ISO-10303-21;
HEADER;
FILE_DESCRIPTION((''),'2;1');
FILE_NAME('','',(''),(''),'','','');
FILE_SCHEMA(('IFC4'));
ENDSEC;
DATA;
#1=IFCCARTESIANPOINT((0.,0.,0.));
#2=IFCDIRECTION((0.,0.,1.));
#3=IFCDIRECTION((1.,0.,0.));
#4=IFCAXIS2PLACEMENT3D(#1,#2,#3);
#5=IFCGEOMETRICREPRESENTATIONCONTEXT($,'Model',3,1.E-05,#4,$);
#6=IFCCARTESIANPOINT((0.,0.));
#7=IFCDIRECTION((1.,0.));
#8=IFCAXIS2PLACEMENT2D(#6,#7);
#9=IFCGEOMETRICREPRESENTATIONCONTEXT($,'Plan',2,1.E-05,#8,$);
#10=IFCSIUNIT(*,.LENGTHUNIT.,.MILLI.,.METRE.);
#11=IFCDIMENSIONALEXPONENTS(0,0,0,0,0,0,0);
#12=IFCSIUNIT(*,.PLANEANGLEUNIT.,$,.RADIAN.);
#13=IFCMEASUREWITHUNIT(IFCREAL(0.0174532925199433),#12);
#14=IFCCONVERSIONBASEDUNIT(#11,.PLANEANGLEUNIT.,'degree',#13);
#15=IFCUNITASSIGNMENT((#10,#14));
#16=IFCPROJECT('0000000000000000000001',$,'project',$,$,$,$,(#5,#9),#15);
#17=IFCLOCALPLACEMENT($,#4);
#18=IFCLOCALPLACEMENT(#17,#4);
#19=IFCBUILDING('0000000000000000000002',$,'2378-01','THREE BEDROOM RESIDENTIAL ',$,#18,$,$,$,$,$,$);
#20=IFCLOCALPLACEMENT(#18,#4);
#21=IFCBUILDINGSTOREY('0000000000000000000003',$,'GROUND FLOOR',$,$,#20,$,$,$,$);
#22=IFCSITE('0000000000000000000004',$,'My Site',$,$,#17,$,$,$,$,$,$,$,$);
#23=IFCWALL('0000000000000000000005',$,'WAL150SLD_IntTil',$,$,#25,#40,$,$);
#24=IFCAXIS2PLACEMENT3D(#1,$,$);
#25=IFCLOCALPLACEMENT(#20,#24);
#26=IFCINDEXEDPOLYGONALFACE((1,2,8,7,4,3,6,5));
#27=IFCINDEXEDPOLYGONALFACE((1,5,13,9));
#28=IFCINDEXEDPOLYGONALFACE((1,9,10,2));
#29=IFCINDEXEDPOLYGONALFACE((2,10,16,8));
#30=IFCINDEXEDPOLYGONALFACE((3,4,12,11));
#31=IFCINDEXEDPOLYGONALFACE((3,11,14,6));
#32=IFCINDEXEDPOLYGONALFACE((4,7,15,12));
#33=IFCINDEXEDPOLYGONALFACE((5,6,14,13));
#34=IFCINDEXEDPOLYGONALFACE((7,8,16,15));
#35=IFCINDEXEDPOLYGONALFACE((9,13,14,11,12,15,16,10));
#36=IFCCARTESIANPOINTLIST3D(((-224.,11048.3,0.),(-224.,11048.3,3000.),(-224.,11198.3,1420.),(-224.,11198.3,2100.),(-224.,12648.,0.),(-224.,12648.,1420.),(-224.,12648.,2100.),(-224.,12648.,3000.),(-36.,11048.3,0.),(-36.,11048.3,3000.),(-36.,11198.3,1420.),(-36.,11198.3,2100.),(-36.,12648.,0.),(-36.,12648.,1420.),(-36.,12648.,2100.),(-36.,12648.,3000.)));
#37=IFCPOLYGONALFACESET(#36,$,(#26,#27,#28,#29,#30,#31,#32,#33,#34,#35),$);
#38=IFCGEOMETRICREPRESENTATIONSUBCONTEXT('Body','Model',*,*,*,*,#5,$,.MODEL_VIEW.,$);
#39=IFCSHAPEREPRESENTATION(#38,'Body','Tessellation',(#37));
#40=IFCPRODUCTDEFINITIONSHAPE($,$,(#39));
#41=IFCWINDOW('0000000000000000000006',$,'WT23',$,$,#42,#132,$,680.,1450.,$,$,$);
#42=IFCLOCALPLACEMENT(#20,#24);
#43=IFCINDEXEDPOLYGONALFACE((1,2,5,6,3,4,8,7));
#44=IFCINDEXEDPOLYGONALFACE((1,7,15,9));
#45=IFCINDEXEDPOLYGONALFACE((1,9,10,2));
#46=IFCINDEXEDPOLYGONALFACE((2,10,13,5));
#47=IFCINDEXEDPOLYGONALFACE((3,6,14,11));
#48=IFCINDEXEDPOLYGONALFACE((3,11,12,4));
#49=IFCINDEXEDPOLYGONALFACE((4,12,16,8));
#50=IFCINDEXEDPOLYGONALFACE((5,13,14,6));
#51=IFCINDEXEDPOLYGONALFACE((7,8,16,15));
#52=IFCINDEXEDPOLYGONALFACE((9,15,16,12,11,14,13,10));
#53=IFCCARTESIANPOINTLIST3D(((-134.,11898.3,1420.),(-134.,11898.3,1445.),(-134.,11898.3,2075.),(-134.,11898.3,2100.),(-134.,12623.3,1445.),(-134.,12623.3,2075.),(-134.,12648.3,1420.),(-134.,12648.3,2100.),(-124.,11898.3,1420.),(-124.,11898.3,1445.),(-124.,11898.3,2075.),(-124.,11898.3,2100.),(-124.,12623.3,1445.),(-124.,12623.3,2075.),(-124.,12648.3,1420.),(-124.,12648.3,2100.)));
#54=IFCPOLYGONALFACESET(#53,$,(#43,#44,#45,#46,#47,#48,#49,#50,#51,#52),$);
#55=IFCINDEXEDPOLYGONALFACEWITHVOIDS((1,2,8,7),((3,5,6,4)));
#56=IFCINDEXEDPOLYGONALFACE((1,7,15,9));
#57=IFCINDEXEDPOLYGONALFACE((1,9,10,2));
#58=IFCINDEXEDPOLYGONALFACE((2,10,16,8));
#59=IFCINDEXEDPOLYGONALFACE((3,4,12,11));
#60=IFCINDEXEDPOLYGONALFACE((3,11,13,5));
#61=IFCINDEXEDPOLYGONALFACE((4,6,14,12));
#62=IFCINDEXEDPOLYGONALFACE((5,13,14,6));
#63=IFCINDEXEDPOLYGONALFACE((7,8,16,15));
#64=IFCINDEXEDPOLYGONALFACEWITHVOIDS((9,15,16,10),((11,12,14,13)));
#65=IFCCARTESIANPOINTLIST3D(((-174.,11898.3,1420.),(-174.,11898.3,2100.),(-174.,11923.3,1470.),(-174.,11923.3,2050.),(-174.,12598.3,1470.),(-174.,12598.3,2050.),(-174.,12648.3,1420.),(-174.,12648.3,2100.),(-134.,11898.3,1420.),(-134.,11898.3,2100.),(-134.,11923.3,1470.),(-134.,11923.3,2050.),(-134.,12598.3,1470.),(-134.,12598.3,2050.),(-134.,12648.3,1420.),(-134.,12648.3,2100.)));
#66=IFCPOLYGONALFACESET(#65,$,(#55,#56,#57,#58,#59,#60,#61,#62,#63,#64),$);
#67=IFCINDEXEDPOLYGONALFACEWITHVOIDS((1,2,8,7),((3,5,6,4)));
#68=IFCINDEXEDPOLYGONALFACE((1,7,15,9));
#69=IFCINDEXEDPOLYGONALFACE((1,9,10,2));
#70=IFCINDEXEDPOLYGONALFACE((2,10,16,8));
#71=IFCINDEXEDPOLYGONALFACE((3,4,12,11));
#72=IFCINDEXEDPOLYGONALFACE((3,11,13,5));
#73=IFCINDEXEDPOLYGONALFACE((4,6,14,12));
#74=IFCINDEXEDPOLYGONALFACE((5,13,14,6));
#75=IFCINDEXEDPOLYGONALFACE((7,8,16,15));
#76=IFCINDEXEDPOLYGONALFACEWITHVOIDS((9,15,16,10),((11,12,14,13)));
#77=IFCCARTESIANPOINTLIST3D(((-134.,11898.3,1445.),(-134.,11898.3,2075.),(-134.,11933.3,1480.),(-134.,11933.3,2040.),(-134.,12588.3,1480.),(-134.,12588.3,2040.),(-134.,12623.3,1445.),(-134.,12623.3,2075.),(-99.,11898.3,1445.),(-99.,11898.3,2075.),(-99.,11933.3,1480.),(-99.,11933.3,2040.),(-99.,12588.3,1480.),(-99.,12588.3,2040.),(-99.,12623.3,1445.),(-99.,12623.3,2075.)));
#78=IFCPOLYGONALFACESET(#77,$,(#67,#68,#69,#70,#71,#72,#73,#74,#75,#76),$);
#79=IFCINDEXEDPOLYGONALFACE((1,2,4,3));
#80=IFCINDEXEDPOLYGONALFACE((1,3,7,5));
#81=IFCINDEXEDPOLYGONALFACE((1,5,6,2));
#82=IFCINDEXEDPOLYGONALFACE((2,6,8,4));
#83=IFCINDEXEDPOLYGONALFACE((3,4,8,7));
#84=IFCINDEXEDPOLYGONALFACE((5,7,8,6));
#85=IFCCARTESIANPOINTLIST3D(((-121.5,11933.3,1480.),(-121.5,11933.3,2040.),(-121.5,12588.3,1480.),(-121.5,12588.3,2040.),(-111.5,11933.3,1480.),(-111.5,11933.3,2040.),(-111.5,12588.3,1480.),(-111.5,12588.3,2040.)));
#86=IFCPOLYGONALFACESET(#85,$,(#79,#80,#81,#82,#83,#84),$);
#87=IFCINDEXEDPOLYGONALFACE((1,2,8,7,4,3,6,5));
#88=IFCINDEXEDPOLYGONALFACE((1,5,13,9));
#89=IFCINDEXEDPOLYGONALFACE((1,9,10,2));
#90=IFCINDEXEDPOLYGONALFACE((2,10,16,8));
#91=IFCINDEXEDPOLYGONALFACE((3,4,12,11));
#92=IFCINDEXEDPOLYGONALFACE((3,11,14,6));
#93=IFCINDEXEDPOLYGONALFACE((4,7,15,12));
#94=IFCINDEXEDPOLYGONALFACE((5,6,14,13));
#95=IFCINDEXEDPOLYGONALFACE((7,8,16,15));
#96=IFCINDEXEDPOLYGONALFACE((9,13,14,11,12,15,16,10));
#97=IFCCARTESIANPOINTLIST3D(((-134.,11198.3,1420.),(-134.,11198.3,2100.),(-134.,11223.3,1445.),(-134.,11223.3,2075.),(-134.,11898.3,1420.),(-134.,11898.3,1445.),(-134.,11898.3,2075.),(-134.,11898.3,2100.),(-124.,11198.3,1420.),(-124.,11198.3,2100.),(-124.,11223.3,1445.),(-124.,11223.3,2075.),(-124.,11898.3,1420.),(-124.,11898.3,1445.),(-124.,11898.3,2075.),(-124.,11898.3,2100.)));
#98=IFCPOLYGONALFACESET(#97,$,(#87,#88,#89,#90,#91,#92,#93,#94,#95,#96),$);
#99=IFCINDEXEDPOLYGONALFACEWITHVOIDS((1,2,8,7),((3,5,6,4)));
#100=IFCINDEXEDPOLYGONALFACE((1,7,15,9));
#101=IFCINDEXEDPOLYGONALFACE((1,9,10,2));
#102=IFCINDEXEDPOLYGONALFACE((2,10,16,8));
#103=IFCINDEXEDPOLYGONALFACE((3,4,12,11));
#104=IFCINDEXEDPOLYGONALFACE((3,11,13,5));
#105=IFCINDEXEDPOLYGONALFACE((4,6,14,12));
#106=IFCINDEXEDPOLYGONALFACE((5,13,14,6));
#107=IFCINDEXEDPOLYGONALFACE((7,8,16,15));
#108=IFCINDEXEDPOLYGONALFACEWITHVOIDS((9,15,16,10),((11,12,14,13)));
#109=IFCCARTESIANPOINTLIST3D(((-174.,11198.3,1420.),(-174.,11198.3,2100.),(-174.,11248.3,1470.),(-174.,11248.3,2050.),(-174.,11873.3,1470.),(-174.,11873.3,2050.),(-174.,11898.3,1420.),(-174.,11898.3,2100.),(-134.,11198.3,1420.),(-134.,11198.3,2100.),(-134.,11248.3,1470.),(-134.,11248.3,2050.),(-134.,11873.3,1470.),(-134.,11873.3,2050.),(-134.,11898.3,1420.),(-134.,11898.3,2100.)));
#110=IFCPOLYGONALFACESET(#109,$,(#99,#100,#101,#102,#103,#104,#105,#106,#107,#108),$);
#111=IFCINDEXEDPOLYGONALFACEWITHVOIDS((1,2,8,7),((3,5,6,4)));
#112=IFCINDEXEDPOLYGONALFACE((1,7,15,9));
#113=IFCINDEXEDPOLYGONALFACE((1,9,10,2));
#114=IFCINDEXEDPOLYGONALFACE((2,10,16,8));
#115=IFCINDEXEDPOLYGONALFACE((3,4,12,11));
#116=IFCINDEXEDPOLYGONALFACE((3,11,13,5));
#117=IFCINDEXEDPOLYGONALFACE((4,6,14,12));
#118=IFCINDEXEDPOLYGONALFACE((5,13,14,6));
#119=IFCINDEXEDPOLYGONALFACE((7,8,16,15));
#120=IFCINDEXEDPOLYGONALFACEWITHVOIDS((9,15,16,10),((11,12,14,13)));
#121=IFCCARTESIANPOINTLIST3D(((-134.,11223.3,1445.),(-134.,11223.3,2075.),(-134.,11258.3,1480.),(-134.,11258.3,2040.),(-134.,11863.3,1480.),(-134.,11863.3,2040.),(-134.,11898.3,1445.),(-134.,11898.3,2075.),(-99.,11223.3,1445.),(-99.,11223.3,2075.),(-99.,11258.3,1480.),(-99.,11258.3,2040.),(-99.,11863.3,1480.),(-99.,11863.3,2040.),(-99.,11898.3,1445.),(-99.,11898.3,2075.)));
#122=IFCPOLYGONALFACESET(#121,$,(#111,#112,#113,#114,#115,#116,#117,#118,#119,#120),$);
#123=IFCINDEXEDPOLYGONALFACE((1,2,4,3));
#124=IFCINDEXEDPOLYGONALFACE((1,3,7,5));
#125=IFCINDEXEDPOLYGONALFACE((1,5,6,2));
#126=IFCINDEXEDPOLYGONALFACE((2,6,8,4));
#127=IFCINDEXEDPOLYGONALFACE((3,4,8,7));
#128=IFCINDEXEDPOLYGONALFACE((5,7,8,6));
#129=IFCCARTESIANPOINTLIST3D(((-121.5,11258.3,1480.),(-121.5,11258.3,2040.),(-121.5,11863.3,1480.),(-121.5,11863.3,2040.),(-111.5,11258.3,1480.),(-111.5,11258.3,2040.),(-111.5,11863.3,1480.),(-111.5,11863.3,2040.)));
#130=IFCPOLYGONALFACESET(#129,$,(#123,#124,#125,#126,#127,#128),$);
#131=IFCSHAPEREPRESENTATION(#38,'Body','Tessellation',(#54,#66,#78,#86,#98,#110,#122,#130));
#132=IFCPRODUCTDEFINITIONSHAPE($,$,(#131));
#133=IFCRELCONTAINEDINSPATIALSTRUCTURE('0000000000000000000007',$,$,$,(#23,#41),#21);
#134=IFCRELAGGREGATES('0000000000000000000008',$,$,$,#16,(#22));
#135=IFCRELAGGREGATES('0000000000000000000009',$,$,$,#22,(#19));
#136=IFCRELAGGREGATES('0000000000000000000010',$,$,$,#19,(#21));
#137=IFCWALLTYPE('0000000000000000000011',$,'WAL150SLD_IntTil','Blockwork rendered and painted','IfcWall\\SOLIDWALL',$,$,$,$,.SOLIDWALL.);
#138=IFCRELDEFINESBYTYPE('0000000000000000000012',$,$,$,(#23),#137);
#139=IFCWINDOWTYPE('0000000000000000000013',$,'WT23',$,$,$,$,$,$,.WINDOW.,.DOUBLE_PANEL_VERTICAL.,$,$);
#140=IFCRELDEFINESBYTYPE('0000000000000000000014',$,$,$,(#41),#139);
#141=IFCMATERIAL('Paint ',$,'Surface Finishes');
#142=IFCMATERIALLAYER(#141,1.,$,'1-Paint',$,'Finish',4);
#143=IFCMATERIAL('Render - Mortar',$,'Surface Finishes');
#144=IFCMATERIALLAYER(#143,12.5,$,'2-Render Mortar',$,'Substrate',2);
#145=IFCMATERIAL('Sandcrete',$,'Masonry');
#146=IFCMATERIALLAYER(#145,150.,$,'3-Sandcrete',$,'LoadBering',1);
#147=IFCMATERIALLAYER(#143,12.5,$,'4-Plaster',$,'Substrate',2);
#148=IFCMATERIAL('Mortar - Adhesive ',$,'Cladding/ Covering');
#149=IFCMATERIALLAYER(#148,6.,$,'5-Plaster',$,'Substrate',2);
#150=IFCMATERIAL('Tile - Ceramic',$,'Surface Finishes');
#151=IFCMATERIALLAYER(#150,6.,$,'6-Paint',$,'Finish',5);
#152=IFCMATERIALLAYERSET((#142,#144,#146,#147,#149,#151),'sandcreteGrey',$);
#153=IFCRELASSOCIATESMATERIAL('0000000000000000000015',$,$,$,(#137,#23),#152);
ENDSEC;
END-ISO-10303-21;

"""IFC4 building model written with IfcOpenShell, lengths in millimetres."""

from ifc_helpers import new_model, entity, si_unit, converted_unit, frame, origin_with_axes, origin_2d_with_axis, place, context, subcontext, project, spatial, line, indexed_curve, outline, extrude, shape, source, transform, mapped, material, layer, layer_set, layer_usage, type_object, type_shapes, element, fill, save


model = new_model("IFC4")

# Units and contexts
model_context = context("Model", 3, precision=1e-05, world=origin_with_axes())
plan_context = context("Plan", 2, precision=1e-05, world=origin_2d_with_axis())
body_context_1 = subcontext(model_context, "Body", "Model", "MODEL_VIEW")
body_context_2 = subcontext(plan_context, "Body", "Plan", "PLAN_VIEW")
ifc_project = project(units=[si_unit("LENGTHUNIT", "METRE", prefix="MILLI"), converted_unit("PLANEANGLEUNIT", "degree", entity("IfcReal", 0.0174532925199433), si_unit("PLANEANGLEUNIT", "RADIAN"), dimensions=[0, 0, 0, 0, 0, 0, 0])], contexts=[model_context, plan_context])

# Site, building, storey
site_placement = place(None, origin_with_axes())
site = spatial("IfcSite", under=ifc_project, at=site_placement, Name="My Site")
building_placement = place(site_placement, origin_with_axes())
building = spatial("IfcBuilding", under=site, at=building_placement, Name="2378-01", Description="THREE BEDROOM RESIDENTIAL ")
storey_placement = place(building_placement, origin_with_axes())
storey = spatial("IfcBuildingStorey", under=building, at=storey_placement, Name="GROUND FLOOR")

# Shared definitions
ifc_material_1 = material(Name="Paint ", Category="Surface Finishes")
ifc_material_2 = material(Name="Render - Mortar", Category="Surface Finishes")
ifc_material_3 = material(Name="Sandcrete", Category="Masonry")

# Shared definitions
ifc_material_4 = material(Name="Mortar - Adhesive ", Category="Cladding/ Covering")
ifc_material_5 = material(Name="Tile - Ceramic", Category="Surface Finishes")

# Shared definitions
ifc_layer_1 = layer(ifc_material_1, 1.0, Name="1-Paint", Category="Finish", Priority=4)
ifc_layer_2 = layer(ifc_material_2, 12.5, Name="2-Render Mortar", Category="Substrate", Priority=2)
ifc_layer_3 = layer(ifc_material_3, 150.0, Name="3-Sandcrete", Category="LoadBering", Priority=1)
ifc_layer_4 = layer(ifc_material_2, 12.5, Name="4-Plaster", Category="Substrate", Priority=2)
ifc_layer_5 = layer(ifc_material_4, 6.0, Name="5-Plaster", Category="Substrate", Priority=2)
ifc_layer_6 = layer(ifc_material_5, 6.0, Name="6-Paint", Category="Finish", Priority=5)
ifc_layer_set_1 = layer_set([ifc_layer_1, ifc_layer_2, ifc_layer_3, ifc_layer_4, ifc_layer_5, ifc_layer_6], Name="sandcreteGrey")
wall_type_1 = type_object("IfcWallType", Name="WAL150SLD_IntTil", Description="Blockwork rendered and painted", ApplicableOccurrence="IfcWall\\SOLIDWALL", PredefinedType="SOLIDWALL", material=ifc_layer_set_1)

# Wall, opening, window
ifc_layer_usage_1 = layer_usage(ifc_layer_set_1, "AXIS2", "POSITIVE", 0.0)
wall_1_placement = place(storey_placement, frame((-224.0, 12648.0, 0.0), z_axis=(0.0, 0.0, 1.0), x_axis=(0.0, -1.0, 0.0)))
wall_1 = element("IfcWall", 1, at=wall_1_placement, inside=storey, type_object=wall_type_1, material=ifc_layer_usage_1, Name="WAL150SLD_IntTil", context=body_context_1, shape_type="SweptSolid", body=[
    extrude(outline(indexed_curve([(0.0, 0.0), (0.0, 188.0), (1599.7, 188.0), (1599.7, 0.0), (0.0, 0.0)], self_intersect=False)), origin_with_axes(), (0.0, 0.0, 1.0), 3000.0),
])
shared_shape_1 = source(origin_with_axes(), body_context_1, "Body", "SweptSolid", [
    extrude(outline(indexed_curve([(0.0, 0.0), (1450.0, 0.0), (1450.0, 680.0), (0.0, 680.0)], segments=[line(1, 2, 3, 4, 1)])), frame((0.0, -600.0, 0.0), z_axis=(0.0, -1.0, 0.0), x_axis=(1.0, 0.0, 0.0)), (0.0, 0.0, -1.0), 1200.0),
])
opening_1_placement = place(wall_1_placement, frame((-0.3, 0.0, 1420.0), z_axis=(0.0, 0.0, 1.0), x_axis=(1.0, 0.0, 0.0)))
opening_1 = element("IfcOpeningElement", 2, at=opening_1_placement, cuts=wall_1, PredefinedType="OPENING", context=body_context_1, shape_type="MappedRepresentation", body=[
    mapped(shared_shape_1, transform((0.0, 0.0, 0.0), x_axis=(1.0, 0.0, 0.0), y_axis=(0.0, 1.0, 0.0), z_axis=(0.0, 0.0, 1.0), scale=1.0)),
])
window_type_1 = type_object("IfcWindowType", Name="WT23", PartitioningType="DOUBLE_PANEL_VERTICAL", PredefinedType="WINDOW")
shared_shape_2 = source(origin_with_axes(), body_context_1, "Body", "SweptSolid", [
    extrude(outline(indexed_curve([(750.0, 0.0), (0.0, 0.0), (0.0, 680.0), (750.0, 680.0), (750.0, 655.0), (25.0, 655.0), (25.0, 25.0), (750.0, 25.0)], segments=[line(1, 2, 3, 4, 5, 6, 7, 8, 1)])), frame((0.0, 90.0, 0.0), z_axis=(0.0, -1.0, 0.0), x_axis=(1.0, 0.0, 0.0)), (0.0, 0.0, -1.0), 10.0),
    extrude(outline(indexed_curve([(0.0, 0.0), (750.0, 0.0), (750.0, 680.0), (0.0, 680.0)], segments=[line(1, 2, 3, 4, 1)]), holes=[indexed_curve([(50.0, 50.0), (725.0, 50.0), (725.0, 630.0), (50.0, 630.0)], segments=[line(1, 2, 3, 4, 1)])]), frame((0.0, 50.0, 0.0), z_axis=(0.0, -1.0, 0.0), x_axis=(1.0, 0.0, 0.0)), (0.0, 0.0, -1.0), 40.0),
    extrude(outline(indexed_curve([(0.0, 0.0), (725.0, 0.0), (725.0, 630.0), (0.0, 630.0)], segments=[line(1, 2, 3, 4, 1)]), holes=[indexed_curve([(35.0, 35.0), (690.0, 35.0), (690.0, 595.0), (35.0, 595.0)], segments=[line(1, 2, 3, 4, 1)])]), frame((25.0, 90.0, 25.0), z_axis=(0.0, -1.0, 0.0), x_axis=(1.0, 0.0, 0.0)), (0.0, 0.0, -1.0), 35.0),
    extrude(outline(indexed_curve([(35.0, 35.0), (690.0, 35.0), (690.0, 595.0), (35.0, 595.0)], segments=[line(1, 2, 3, 4, 1)])), frame((25.0, 102.5, 25.0), z_axis=(0.0, -1.0, 0.0), x_axis=(1.0, 0.0, 0.0)), (0.0, 0.0, -1.0), 10.0),
    extrude(outline(indexed_curve([(0.0, 680.0), (700.0, 680.0), (700.0, 0.0), (0.0, 0.0), (0.0, 25.0), (675.0, 25.0), (675.0, 655.0), (0.0, 655.0)], segments=[line(1, 2, 3, 4, 5, 6, 7, 8, 1)])), frame((750.0, 90.0, 0.0), z_axis=(0.0, -1.0, 0.0), x_axis=(1.0, 0.0, 0.0)), (0.0, 0.0, -1.0), 10.0),
    extrude(outline(indexed_curve([(0.0, 0.0), (700.0, 0.0), (700.0, 680.0), (0.0, 680.0)], segments=[line(1, 2, 3, 4, 1)]), holes=[indexed_curve([(25.0, 50.0), (650.0, 50.0), (650.0, 630.0), (25.0, 630.0)], segments=[line(1, 2, 3, 4, 1)])]), frame((750.0, 50.0, 0.0), z_axis=(0.0, -1.0, 0.0), x_axis=(1.0, 0.0, 0.0)), (0.0, 0.0, -1.0), 40.0),
    extrude(outline(indexed_curve([(0.0, 0.0), (675.0, 0.0), (675.0, 630.0), (0.0, 630.0)], segments=[line(1, 2, 3, 4, 1)]), holes=[indexed_curve([(35.0, 35.0), (640.0, 35.0), (640.0, 595.0), (35.0, 595.0)], segments=[line(1, 2, 3, 4, 1)])]), frame((750.0, 90.0, 25.0), z_axis=(0.0, -1.0, 0.0), x_axis=(1.0, 0.0, 0.0)), (0.0, 0.0, -1.0), 35.0),
    extrude(outline(indexed_curve([(35.0, 35.0), (640.0, 35.0), (640.0, 595.0), (35.0, 595.0)], segments=[line(1, 2, 3, 4, 1)])), frame((750.0, 102.5, 25.0), z_axis=(0.0, -1.0, 0.0), x_axis=(1.0, 0.0, 0.0)), (0.0, 0.0, -1.0), 10.0),
])
shared_shape_3 = source(origin_with_axes(), body_context_2, "Body", "Curve2D", [
    entity("IfcIndexedPolyCurve", entity("IfcCartesianPointList2D", [[50.0, 50.0], [725.0, 50.0]])),
    entity("IfcIndexedPolyCurve", entity("IfcCartesianPointList2D", [[0.0, 100.0], [25.0, 100.0], [25.0, 90.0], [50.0, 90.0], [50.0, 50.0], [0.0, 50.0]]), [entity("IfcLineIndex", [1, 2, 3, 4, 5, 6, 1])]),
    entity("IfcIndexedPolyCurve", entity("IfcCartesianPointList2D", [[750.0, 100.0], [750.0, 100.0], [750.0, 90.0], [725.0, 90.0], [725.0, 50.0], [750.0, 50.0]])),
    entity("IfcIndexedPolyCurve", entity("IfcCartesianPointList2D", [[25.0, 90.0], [60.0, 90.0], [60.0, 125.0], [25.0, 125.0]]), [entity("IfcLineIndex", [1, 2, 3, 4, 1])]),
    entity("IfcIndexedPolyCurve", entity("IfcCartesianPointList2D", [[750.0, 90.0], [715.0, 90.0], [715.0, 125.0], [750.0, 125.0]]), [entity("IfcLineIndex", [1, 2, 3, 4, 1])]),
    entity("IfcIndexedPolyCurve", entity("IfcCartesianPointList2D", [[60.0, 90.0], [715.0, 90.0]])),
    entity("IfcIndexedPolyCurve", entity("IfcCartesianPointList2D", [[60.0, 125.0], [715.0, 125.0]])),
    entity("IfcIndexedPolyCurve", entity("IfcCartesianPointList2D", [[60.0, 107.5], [715.0, 107.5]])),
    entity("IfcIndexedPolyCurve", entity("IfcCartesianPointList2D", [[775.0, 50.0], [1400.0, 50.0]])),
    entity("IfcIndexedPolyCurve", entity("IfcCartesianPointList2D", [[750.0, 100.0], [750.0, 100.0], [750.0, 90.0], [775.0, 90.0], [775.0, 50.0], [750.0, 50.0]])),
    entity("IfcIndexedPolyCurve", entity("IfcCartesianPointList2D", [[1450.0, 100.0], [1425.0, 100.0], [1425.0, 90.0], [1400.0, 90.0], [1400.0, 50.0], [1450.0, 50.0]]), [entity("IfcLineIndex", [1, 2, 3, 4, 5, 6, 1])]),
    entity("IfcIndexedPolyCurve", entity("IfcCartesianPointList2D", [[750.0, 90.0], [785.0, 90.0], [785.0, 125.0], [750.0, 125.0]]), [entity("IfcLineIndex", [1, 2, 3, 4, 1])]),
    entity("IfcIndexedPolyCurve", entity("IfcCartesianPointList2D", [[1425.0, 90.0], [1390.0, 90.0], [1390.0, 125.0], [1425.0, 125.0]]), [entity("IfcLineIndex", [1, 2, 3, 4, 1])]),
    entity("IfcIndexedPolyCurve", entity("IfcCartesianPointList2D", [[785.0, 90.0], [1390.0, 90.0]])),
    entity("IfcIndexedPolyCurve", entity("IfcCartesianPointList2D", [[785.0, 125.0], [1390.0, 125.0]])),
    entity("IfcIndexedPolyCurve", entity("IfcCartesianPointList2D", [[785.0, 107.5], [1390.0, 107.5]])),
])
type_shapes(window_type_1, [shared_shape_2, shared_shape_3])
window_1_placement = place(opening_1_placement, frame((0.0, 0.0, 0.0), z_axis=(0.0, 0.0, 1.0), x_axis=(1.0, 0.0, 0.0)))
window_1 = element("IfcWindow", 3, at=window_1_placement, inside=storey, type_object=window_type_1, Name="WT23", OverallHeight=680.0, OverallWidth=1450.0, shapes=[
    shape(body_context_1, "Body", "MappedRepresentation", [mapped(shared_shape_2, transform((0.0, 0.0, 0.0), x_axis=(1.0, 0.0, 0.0), y_axis=(0.0, 1.0, 0.0), z_axis=(0.0, 0.0, 1.0), scale=1.0))]),
    shape(body_context_2, "Body", "MappedRepresentation", [mapped(shared_shape_3, transform((0.0, 0.0, 0.0), x_axis=(1.0, 0.0, 0.0), y_axis=(0.0, 1.0, 0.0), z_axis=(0.0, 0.0, 1.0), scale=1.0))]),
])
fill(opening_1, window_1)

save(model, "model.ifc")
